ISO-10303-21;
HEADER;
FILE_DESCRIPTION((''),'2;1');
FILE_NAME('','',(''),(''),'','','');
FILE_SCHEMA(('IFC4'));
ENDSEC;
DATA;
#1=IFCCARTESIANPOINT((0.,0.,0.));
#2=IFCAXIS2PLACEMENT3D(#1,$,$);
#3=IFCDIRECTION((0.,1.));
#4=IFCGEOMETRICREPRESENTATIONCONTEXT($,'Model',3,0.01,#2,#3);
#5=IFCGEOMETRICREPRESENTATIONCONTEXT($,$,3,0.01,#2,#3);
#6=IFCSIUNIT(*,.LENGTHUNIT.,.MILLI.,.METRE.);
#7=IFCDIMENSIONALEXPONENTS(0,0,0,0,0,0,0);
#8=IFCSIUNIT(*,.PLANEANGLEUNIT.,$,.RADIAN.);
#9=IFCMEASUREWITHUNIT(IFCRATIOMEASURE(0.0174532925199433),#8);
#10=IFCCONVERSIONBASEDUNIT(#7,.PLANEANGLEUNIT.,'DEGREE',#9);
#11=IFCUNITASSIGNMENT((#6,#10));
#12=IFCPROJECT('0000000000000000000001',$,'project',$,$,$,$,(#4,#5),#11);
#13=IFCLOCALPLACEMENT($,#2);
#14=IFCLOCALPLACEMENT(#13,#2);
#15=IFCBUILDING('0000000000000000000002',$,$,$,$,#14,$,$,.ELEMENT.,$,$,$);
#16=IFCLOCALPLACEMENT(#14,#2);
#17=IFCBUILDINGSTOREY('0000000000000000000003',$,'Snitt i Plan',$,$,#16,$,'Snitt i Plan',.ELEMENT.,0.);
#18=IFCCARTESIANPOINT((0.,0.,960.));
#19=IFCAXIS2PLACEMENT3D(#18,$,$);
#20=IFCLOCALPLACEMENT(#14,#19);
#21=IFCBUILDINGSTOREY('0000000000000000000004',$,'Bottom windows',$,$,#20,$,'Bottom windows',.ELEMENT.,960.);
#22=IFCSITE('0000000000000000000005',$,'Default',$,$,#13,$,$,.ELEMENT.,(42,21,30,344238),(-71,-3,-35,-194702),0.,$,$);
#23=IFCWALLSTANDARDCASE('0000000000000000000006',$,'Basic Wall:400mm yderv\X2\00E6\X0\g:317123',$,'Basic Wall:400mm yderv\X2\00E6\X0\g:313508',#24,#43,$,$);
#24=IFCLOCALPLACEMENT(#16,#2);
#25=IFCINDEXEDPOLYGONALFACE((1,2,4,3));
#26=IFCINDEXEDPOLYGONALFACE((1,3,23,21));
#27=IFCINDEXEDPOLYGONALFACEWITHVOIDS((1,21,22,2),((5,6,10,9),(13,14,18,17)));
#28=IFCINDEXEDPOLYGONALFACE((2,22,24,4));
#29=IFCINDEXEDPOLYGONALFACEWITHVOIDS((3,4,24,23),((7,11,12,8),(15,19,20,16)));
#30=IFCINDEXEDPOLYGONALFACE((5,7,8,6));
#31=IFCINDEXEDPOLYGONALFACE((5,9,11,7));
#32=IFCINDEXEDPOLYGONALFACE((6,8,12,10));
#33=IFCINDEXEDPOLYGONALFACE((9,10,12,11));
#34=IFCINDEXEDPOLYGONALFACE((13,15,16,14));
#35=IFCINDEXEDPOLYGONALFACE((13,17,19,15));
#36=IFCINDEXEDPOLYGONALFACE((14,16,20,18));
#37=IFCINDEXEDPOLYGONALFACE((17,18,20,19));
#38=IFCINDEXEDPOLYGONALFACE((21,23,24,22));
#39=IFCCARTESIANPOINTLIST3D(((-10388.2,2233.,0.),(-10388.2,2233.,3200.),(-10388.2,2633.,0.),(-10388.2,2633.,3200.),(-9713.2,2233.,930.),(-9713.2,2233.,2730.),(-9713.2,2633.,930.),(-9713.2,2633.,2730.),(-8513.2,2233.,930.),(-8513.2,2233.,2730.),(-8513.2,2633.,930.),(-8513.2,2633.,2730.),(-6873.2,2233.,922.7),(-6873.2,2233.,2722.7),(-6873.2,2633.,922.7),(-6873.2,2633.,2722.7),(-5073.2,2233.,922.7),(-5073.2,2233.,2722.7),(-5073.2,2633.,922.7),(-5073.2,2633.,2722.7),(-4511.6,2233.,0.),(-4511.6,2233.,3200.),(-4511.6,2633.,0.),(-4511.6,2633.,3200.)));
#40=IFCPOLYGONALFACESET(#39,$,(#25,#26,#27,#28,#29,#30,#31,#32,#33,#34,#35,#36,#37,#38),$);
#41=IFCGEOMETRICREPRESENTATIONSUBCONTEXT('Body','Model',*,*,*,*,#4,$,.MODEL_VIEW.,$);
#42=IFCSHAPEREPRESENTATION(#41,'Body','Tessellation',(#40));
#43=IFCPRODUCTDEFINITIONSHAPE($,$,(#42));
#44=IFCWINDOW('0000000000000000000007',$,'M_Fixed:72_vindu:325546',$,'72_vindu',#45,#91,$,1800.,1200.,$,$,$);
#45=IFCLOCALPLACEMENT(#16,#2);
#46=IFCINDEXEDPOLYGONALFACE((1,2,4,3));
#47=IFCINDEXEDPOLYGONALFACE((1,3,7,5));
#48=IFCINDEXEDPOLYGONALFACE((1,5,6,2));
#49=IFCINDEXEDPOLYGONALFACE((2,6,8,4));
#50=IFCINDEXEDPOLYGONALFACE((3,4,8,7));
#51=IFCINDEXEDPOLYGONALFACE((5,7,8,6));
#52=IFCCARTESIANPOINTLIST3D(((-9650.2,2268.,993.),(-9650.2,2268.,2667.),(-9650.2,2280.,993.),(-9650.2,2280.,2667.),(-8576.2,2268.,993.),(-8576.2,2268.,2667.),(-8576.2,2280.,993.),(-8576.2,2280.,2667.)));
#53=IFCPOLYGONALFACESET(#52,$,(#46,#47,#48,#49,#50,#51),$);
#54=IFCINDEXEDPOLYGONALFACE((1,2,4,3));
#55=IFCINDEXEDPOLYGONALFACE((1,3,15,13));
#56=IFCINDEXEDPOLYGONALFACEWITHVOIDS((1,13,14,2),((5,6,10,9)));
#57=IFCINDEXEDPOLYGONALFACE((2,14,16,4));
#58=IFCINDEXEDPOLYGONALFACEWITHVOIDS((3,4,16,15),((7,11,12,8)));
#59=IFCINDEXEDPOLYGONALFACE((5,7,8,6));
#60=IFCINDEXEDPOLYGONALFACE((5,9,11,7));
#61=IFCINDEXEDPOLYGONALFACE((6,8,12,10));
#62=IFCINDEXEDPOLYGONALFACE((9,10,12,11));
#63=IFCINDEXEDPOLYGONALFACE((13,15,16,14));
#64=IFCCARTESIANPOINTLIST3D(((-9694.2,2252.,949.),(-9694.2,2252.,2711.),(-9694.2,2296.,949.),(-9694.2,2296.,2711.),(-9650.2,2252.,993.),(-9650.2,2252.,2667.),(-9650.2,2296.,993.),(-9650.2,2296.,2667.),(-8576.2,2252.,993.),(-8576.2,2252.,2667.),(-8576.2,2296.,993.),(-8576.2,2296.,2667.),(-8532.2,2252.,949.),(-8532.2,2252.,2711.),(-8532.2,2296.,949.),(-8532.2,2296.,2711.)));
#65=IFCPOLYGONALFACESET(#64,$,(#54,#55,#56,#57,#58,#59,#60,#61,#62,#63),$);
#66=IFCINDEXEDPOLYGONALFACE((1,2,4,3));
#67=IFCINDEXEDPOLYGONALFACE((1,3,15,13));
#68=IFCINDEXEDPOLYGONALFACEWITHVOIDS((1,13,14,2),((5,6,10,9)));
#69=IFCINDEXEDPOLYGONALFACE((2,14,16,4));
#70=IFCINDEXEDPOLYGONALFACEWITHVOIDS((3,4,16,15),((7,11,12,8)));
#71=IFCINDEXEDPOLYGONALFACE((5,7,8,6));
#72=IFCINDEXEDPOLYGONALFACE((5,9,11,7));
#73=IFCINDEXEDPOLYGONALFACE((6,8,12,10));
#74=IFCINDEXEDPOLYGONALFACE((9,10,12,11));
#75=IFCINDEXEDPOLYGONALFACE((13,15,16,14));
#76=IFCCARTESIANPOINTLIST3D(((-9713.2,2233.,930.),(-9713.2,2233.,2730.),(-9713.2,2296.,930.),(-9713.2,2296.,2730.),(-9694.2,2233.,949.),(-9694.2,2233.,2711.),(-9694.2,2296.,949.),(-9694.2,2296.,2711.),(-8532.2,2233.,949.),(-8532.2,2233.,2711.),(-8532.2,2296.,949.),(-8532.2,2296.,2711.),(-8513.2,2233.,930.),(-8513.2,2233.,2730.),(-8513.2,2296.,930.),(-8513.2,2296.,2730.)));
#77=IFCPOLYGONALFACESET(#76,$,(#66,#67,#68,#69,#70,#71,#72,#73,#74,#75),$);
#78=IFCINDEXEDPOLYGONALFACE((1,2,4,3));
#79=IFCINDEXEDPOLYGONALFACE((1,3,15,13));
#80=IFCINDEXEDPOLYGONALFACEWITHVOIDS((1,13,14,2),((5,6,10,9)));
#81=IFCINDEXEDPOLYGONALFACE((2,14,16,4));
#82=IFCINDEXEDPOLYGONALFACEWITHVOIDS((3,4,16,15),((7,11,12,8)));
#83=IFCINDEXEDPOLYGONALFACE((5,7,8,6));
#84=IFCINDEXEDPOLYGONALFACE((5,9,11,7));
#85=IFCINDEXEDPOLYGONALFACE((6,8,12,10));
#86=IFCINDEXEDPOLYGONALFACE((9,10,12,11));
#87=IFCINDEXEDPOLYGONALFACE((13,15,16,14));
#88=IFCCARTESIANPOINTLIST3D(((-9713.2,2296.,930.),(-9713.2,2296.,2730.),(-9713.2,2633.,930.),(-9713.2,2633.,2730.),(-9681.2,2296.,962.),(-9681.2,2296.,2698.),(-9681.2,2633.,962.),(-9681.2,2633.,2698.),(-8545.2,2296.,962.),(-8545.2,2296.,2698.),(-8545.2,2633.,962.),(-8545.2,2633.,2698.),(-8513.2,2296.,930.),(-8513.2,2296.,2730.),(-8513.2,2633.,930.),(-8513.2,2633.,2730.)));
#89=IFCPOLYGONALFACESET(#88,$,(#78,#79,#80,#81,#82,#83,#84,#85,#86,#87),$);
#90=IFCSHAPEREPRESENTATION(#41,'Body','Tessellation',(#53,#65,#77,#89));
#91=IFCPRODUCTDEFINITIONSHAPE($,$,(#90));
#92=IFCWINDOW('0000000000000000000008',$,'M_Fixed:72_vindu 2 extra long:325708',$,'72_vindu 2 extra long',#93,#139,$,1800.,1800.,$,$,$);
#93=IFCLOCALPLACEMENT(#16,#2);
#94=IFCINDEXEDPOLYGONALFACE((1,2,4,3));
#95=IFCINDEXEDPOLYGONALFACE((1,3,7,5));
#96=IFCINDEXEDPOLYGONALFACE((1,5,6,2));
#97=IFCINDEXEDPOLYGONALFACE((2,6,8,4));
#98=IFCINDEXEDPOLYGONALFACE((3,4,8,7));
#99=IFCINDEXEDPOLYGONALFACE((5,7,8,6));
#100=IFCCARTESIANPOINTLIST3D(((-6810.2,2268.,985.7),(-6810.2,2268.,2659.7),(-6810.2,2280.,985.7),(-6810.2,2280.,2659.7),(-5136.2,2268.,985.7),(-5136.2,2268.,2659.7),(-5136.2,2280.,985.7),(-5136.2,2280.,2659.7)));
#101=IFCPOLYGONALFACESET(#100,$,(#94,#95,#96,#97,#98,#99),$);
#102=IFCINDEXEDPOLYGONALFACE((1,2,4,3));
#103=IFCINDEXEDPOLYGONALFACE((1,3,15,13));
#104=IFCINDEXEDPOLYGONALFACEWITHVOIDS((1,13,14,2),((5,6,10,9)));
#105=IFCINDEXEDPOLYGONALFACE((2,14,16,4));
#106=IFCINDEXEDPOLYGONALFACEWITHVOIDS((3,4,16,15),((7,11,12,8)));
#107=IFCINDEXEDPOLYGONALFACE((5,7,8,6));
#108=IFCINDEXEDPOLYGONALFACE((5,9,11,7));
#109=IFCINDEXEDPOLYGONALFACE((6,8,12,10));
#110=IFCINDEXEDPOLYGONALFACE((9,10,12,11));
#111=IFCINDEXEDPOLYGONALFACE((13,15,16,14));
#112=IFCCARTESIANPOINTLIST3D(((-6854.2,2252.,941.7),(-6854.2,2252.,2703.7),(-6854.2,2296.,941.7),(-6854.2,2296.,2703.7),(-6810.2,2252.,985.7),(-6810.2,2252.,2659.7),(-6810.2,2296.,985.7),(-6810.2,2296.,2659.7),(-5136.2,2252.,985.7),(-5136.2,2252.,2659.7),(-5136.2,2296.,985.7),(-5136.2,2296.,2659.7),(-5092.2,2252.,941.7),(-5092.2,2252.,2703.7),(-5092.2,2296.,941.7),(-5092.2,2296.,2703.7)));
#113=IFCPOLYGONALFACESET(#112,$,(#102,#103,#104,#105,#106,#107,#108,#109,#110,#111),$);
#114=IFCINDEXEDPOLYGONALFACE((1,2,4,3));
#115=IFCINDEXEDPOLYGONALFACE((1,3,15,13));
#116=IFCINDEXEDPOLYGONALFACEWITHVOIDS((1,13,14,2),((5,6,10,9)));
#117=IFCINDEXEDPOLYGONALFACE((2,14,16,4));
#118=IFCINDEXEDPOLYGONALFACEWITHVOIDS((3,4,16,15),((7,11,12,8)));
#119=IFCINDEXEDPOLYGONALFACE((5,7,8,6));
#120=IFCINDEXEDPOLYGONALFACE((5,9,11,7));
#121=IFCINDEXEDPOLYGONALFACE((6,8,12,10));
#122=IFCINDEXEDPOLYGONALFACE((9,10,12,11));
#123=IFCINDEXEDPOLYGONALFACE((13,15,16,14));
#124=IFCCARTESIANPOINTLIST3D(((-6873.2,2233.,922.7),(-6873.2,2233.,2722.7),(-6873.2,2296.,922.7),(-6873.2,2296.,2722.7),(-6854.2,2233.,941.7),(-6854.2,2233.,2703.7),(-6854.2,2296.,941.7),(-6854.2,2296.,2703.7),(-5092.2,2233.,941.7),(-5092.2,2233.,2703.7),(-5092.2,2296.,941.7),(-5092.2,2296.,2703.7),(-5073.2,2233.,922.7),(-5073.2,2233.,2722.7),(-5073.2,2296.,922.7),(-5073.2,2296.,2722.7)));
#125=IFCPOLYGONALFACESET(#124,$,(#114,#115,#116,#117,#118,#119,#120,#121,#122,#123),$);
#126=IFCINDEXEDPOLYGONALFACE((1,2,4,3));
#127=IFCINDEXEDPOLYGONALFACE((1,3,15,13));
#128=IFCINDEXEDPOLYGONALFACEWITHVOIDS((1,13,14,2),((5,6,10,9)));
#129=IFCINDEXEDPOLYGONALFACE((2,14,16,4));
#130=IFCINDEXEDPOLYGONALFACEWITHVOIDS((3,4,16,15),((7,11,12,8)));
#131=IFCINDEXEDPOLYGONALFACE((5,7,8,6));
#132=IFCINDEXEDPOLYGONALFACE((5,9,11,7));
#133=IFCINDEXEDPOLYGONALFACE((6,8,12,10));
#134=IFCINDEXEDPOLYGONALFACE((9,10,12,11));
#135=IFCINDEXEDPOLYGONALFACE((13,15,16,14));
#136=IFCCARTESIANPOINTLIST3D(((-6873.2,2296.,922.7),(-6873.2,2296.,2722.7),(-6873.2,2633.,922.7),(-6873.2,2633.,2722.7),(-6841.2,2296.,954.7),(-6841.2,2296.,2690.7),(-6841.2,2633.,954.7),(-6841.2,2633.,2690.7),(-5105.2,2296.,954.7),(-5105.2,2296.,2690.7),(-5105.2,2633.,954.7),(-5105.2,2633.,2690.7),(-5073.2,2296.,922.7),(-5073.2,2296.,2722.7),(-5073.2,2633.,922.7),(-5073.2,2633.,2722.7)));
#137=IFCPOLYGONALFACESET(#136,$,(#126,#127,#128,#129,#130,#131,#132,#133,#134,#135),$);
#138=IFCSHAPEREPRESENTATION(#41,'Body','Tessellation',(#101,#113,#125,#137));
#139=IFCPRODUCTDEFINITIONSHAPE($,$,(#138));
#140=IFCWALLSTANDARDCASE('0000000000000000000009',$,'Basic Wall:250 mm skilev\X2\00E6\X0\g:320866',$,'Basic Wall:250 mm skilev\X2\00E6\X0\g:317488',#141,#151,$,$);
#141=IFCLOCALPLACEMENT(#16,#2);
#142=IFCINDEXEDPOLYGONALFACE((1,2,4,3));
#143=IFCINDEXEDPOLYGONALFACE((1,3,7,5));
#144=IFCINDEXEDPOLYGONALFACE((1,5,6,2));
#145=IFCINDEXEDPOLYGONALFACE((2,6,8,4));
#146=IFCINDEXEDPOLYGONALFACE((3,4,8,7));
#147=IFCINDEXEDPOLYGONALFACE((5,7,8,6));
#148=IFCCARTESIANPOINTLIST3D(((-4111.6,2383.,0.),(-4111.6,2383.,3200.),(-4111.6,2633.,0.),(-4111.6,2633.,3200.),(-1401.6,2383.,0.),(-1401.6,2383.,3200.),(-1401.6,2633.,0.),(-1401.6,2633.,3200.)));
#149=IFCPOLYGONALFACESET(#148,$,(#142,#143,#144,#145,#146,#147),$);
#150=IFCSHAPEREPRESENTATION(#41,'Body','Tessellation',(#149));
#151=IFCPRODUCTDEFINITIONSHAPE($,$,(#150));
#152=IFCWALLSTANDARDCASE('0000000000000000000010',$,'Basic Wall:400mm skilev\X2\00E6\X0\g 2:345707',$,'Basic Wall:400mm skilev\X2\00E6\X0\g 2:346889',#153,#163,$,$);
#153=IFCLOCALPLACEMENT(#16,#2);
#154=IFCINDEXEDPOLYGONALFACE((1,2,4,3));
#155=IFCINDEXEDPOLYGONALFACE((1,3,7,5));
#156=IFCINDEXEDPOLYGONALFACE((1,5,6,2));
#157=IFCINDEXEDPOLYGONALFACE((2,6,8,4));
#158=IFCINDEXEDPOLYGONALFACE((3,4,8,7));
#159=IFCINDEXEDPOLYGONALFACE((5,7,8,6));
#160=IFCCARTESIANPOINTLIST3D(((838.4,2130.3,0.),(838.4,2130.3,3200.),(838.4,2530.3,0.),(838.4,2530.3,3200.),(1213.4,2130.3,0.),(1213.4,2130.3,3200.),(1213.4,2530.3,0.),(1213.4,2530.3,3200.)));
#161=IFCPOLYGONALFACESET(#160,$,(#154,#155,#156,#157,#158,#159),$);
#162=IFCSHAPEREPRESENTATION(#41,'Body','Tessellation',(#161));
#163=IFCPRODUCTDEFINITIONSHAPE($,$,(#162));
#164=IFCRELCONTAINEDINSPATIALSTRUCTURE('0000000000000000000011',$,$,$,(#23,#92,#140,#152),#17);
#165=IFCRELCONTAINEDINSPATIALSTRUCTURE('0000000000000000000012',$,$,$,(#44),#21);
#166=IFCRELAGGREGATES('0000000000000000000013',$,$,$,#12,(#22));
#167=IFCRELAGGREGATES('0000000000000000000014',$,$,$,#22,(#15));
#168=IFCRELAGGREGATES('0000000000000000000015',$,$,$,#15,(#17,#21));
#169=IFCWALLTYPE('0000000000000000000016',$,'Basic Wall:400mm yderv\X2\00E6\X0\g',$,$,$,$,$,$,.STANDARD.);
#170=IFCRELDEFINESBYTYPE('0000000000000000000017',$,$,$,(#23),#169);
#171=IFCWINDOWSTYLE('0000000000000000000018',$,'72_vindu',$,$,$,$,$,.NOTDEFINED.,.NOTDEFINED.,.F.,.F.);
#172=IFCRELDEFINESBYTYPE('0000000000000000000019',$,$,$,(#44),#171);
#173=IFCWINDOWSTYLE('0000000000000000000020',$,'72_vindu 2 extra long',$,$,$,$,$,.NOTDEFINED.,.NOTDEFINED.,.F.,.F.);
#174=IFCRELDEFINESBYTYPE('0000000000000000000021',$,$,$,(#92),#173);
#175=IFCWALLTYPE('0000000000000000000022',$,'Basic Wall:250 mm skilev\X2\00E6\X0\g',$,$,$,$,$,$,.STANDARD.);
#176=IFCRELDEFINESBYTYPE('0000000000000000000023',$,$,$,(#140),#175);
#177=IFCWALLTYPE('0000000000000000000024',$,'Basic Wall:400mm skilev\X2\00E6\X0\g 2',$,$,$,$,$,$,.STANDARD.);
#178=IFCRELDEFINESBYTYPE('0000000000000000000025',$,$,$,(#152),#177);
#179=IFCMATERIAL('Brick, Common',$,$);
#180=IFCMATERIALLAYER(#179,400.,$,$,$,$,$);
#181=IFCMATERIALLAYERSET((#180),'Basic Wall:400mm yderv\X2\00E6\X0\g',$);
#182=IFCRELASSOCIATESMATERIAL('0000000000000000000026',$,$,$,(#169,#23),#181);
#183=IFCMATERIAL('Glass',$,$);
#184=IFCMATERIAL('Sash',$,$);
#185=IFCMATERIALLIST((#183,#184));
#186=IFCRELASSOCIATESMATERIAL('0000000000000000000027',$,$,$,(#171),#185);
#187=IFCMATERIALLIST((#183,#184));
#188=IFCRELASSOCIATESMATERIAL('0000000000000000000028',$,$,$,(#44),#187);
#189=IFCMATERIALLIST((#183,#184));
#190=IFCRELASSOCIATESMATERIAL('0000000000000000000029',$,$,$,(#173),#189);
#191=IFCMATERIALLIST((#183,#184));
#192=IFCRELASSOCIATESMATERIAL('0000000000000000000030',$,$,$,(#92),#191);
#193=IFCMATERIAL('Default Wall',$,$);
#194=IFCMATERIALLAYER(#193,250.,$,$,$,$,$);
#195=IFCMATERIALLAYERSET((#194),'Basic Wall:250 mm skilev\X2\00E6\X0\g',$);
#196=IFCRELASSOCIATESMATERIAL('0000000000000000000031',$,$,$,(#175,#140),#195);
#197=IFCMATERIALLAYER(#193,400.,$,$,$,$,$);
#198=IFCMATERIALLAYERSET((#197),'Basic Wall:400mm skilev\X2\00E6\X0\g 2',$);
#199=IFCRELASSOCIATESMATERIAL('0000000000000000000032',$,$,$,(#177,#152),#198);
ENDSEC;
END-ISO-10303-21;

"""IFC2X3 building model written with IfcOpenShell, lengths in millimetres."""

from ifc_helpers import new_model, entity, si_unit, converted_unit, direction, frame, frame_2d, origin, origin_2d_with_axis, place, context, subcontext, project, spatial, polyline, rectangle, outline, extrude, source, transform, mapped, material, material_list, layer, layer_set, layer_usage, type_object, type_shapes, element, fill, save


model = new_model("IFC2X3")

# Units and contexts
model_context = context("Model", 3, precision=0.01, world=origin(), true_north=direction((0.0, 1.0)))
context_of_model = context(None, 3, precision=0.01, world=origin(), true_north=direction((0.0, 1.0)))
body_context = subcontext(model_context, "Body", "Model", "MODEL_VIEW")
ifc_project = project(units=[si_unit("LENGTHUNIT", "METRE", prefix="MILLI"), converted_unit("PLANEANGLEUNIT", "DEGREE", entity("IfcRatioMeasure", 0.0174532925199433), si_unit("PLANEANGLEUNIT", "RADIAN"), dimensions=[0, 0, 0, 0, 0, 0, 0])], contexts=[model_context, context_of_model])

# Site, building, storey
site_placement = place(None, origin())
site = spatial("IfcSite", under=ifc_project, at=site_placement, Name="Default", CompositionType="ELEMENT", RefLatitude=(42, 21, 30, 344238), RefLongitude=(-71, -3, -35, -194702), RefElevation=0.0)
building_placement = place(site_placement, origin())
building = spatial("IfcBuilding", under=site, at=building_placement, CompositionType="ELEMENT")
storey_1_placement = place(building_placement, origin())
storey_1 = spatial("IfcBuildingStorey", under=building, at=storey_1_placement, Name="Snitt i Plan", LongName="Snitt i Plan", CompositionType="ELEMENT", Elevation=0.0)

# Wall, openings
ifc_material_1 = material(Name="Brick, Common")
ifc_layer_1 = layer(ifc_material_1, 400.0)
ifc_layer_set_1 = layer_set([ifc_layer_1], Name="Basic Wall:400mm ydervæg")
ifc_layer_usage_1 = layer_usage(ifc_layer_set_1, "AXIS2", "NEGATIVE", 200.0)
wall_type_1 = type_object("IfcWallType", Name="Basic Wall:400mm ydervæg", PredefinedType="STANDARD", material=ifc_layer_set_1)
wall_1_placement = place(storey_1_placement, frame((-4511.6, 2433.0, 0.0), z_axis=(0.0, 0.0, 1.0), x_axis=(-1.0, 0.0, 0.0)))
wall_1 = element("IfcWallStandardCase", 1, at=wall_1_placement, inside=storey_1, type_object=wall_type_1, material=ifc_layer_usage_1, Name="Basic Wall:400mm ydervæg:317123", ObjectType="Basic Wall:400mm ydervæg:313508", context=body_context, shape_type="SweptSolid", body=[
    extrude(rectangle(XDim=5876.6, YDim=400.0, at=frame_2d((2938.3, 0.0), x_axis=(-1.0, 0.0))), origin(), (0.0, 0.0, 1.0), 3200.0),
])
opening_1_placement = place(wall_1_placement, frame((4001.6, -200.0, 930.0)))
opening_1 = element("IfcOpeningElement", 2, at=opening_1_placement, cuts=wall_1, ObjectType="Opening", context=body_context, shape_type="SweptSolid", body=[
    extrude(rectangle(XDim=1800.0, YDim=1200.0, at=frame_2d((900.0, 600.0), x_axis=(1.0, 0.0))), frame((0.0, 0.0, 0.0), z_axis=(0.0, 1.0, 0.0), x_axis=(0.0, 0.0, 1.0)), (0.0, 0.0, 1.0), 400.0),
])
opening_2_placement = place(wall_1_placement, frame((561.6, -200.0, 922.7)))
opening_2 = element("IfcOpeningElement", 3, at=opening_2_placement, cuts=wall_1, ObjectType="Opening", context=body_context, shape_type="SweptSolid", body=[
    extrude(rectangle(XDim=1800.0, YDim=1800.0, at=frame_2d((900.0, 900.0), x_axis=(1.0, 0.0))), frame((0.0, 0.0, 0.0), z_axis=(0.0, 1.0, 0.0), x_axis=(0.0, 0.0, 1.0)), (0.0, 0.0, 1.0), 400.0),
])

# Shared definitions
storey_2_placement = place(building_placement, frame((0.0, 0.0, 960.0)))
storey_2 = spatial("IfcBuildingStorey", under=building, at=storey_2_placement, Name="Bottom windows", LongName="Bottom windows", CompositionType="ELEMENT", Elevation=960.0)

# Windows
ifc_material_2 = material(Name="Glass")
ifc_material_3 = material(Name="Sash")
ifc_material_list_1 = material_list([ifc_material_2, ifc_material_3])
ifc_material_list_2 = material_list([ifc_material_2, ifc_material_3])
window_style_1 = type_object("IfcWindowStyle", Name="72_vindu", ConstructionType="NOTDEFINED", OperationType="NOTDEFINED", ParameterTakesPrecedence=False, Sizeable=False, material=ifc_material_list_2)
shared_shape_1 = source(origin(), body_context, "Body", "SweptSolid", [
    extrude(rectangle(XDim=12.0, YDim=1074.0, at=origin_2d_with_axis()), frame((600.0, 359.0, 63.0), z_axis=(0.0, 0.0, 1.0), x_axis=(0.0, -1.0, 0.0)), (0.0, 0.0, 1.0), 1674.0),
    extrude(outline(polyline([(-581.0, -881.0), (581.0, -881.0), (581.0, 881.0), (-581.0, 881.0), (-581.0, -881.0)]), holes=[polyline([(-537.0, -837.0), (-537.0, 837.0), (537.0, 837.0), (537.0, -837.0), (-537.0, -837.0)])]), frame((600.0, 337.0, 900.0), z_axis=(0.0, 1.0, 0.0), x_axis=(1.0, 0.0, 0.0)), (0.0, 0.0, 1.0), 44.0),
    extrude(outline(polyline([(-600.0, -900.0), (600.0, -900.0), (600.0, 900.0), (-600.0, 900.0), (-600.0, -900.0)]), holes=[polyline([(-581.0, -881.0), (-581.0, 881.0), (581.0, 881.0), (581.0, -881.0), (-581.0, -881.0)])]), frame((600.0, 337.0, 900.0), z_axis=(0.0, 1.0, 0.0), x_axis=(1.0, 0.0, 0.0)), (0.0, 0.0, 1.0), 63.0),
    extrude(outline(polyline([(-600.0, -900.0), (600.0, -900.0), (600.0, 900.0), (-600.0, 900.0), (-600.0, -900.0)]), holes=[polyline([(-568.0, -868.0), (-568.0, 868.0), (568.0, 868.0), (568.0, -868.0), (-568.0, -868.0)])]), frame((600.0, 0.0, 900.0), z_axis=(0.0, 1.0, 0.0), x_axis=(1.0, 0.0, 0.0)), (0.0, 0.0, 1.0), 337.0),
])
type_shapes(window_style_1, [shared_shape_1])
window_1_placement = place(opening_1_placement, origin())
window_1 = element("IfcWindow", 4, at=window_1_placement, inside=storey_2, type_object=window_style_1, material=ifc_material_list_1, Name="M_Fixed:72_vindu:325546", ObjectType="72_vindu", OverallHeight=1800.0, OverallWidth=1200.0, context=body_context, shape_type="MappedRepresentation", body=[
    mapped(shared_shape_1, transform((0.0, 0.0, 0.0), scale=1.0)),
])
fill(opening_1, window_1)
ifc_material_list_3 = material_list([ifc_material_2, ifc_material_3])
ifc_material_list_4 = material_list([ifc_material_2, ifc_material_3])
window_style_2 = type_object("IfcWindowStyle", Name="72_vindu 2 extra long", ConstructionType="NOTDEFINED", OperationType="NOTDEFINED", ParameterTakesPrecedence=False, Sizeable=False, material=ifc_material_list_4)
shared_shape_2 = source(origin(), body_context, "Body", "SweptSolid", [
    extrude(rectangle(XDim=12.0, YDim=1674.0, at=origin_2d_with_axis()), frame((900.0, 359.0, 63.0), z_axis=(0.0, 0.0, 1.0), x_axis=(0.0, -1.0, 0.0)), (0.0, 0.0, 1.0), 1674.0),
    extrude(outline(polyline([(-881.0, -881.0), (881.0, -881.0), (881.0, 881.0), (-881.0, 881.0), (-881.0, -881.0)]), holes=[polyline([(-837.0, -837.0), (-837.0, 837.0), (837.0, 837.0), (837.0, -837.0), (-837.0, -837.0)])]), frame((900.0, 337.0, 900.0), z_axis=(0.0, 1.0, 0.0), x_axis=(1.0, 0.0, 0.0)), (0.0, 0.0, 1.0), 44.0),
    extrude(outline(polyline([(-900.0, -900.0), (900.0, -900.0), (900.0, 900.0), (-900.0, 900.0), (-900.0, -900.0)]), holes=[polyline([(-881.0, -881.0), (-881.0, 881.0), (881.0, 881.0), (881.0, -881.0), (-881.0, -881.0)])]), frame((900.0, 337.0, 900.0), z_axis=(0.0, 1.0, 0.0), x_axis=(1.0, 0.0, 0.0)), (0.0, 0.0, 1.0), 63.0),
    extrude(outline(polyline([(-900.0, -900.0), (900.0, -900.0), (900.0, 900.0), (-900.0, 900.0), (-900.0, -900.0)]), holes=[polyline([(-868.0, -868.0), (-868.0, 868.0), (868.0, 868.0), (868.0, -868.0), (-868.0, -868.0)])]), frame((900.0, 0.0, 900.0), z_axis=(0.0, 1.0, 0.0), x_axis=(1.0, 0.0, 0.0)), (0.0, 0.0, 1.0), 337.0),
])
type_shapes(window_style_2, [shared_shape_2])
window_2_placement = place(opening_2_placement, origin())
window_2 = element("IfcWindow", 5, at=window_2_placement, inside=storey_1, type_object=window_style_2, material=ifc_material_list_3, Name="M_Fixed:72_vindu 2 extra long:325708", ObjectType="72_vindu 2 extra long", OverallHeight=1800.0, OverallWidth=1800.0, context=body_context, shape_type="MappedRepresentation", body=[
    mapped(shared_shape_2, transform((0.0, 0.0, 0.0), scale=1.0)),
])
fill(opening_2, window_2)

# Walls
ifc_material_4 = material(Name="Default Wall")
ifc_layer_2 = layer(ifc_material_4, 250.0)
ifc_layer_set_2 = layer_set([ifc_layer_2], Name="Basic Wall:250 mm skilevæg")
ifc_layer_usage_2 = layer_usage(ifc_layer_set_2, "AXIS2", "NEGATIVE", 125.0)
wall_type_2 = type_object("IfcWallType", Name="Basic Wall:250 mm skilevæg", PredefinedType="STANDARD", material=ifc_layer_set_2)
wall_2_placement = place(storey_1_placement, frame((-4111.6, 2508.0, 0.0)))
element("IfcWallStandardCase", 6, at=wall_2_placement, inside=storey_1, type_object=wall_type_2, material=ifc_layer_usage_2, Name="Basic Wall:250 mm skilevæg:320866", ObjectType="Basic Wall:250 mm skilevæg:317488", context=body_context, shape_type="SweptSolid", body=[
    extrude(rectangle(XDim=2710.0, YDim=250.0, at=frame_2d((1355.0, 0.0), x_axis=(-1.0, 0.0))), origin(), (0.0, 0.0, 1.0), 3200.0),
])
ifc_layer_3 = layer(ifc_material_4, 400.0)
ifc_layer_set_3 = layer_set([ifc_layer_3], Name="Basic Wall:400mm skilevæg 2")
ifc_layer_usage_3 = layer_usage(ifc_layer_set_3, "AXIS2", "NEGATIVE", 200.0)
wall_type_3 = type_object("IfcWallType", Name="Basic Wall:400mm skilevæg 2", PredefinedType="STANDARD", material=ifc_layer_set_3)
wall_3_placement = place(storey_1_placement, frame((838.4, 2330.3, 0.0)))
element("IfcWallStandardCase", 7, at=wall_3_placement, inside=storey_1, type_object=wall_type_3, material=ifc_layer_usage_3, Name="Basic Wall:400mm skilevæg 2:345707", ObjectType="Basic Wall:400mm skilevæg 2:346889", context=body_context, shape_type="SweptSolid", body=[
    extrude(rectangle(XDim=375.0, YDim=400.0, at=frame_2d((187.5, 0.0), x_axis=(-1.0, 0.0))), origin(), (0.0, 0.0, 1.0), 3200.0),
])

save(model, "model.ifc")
